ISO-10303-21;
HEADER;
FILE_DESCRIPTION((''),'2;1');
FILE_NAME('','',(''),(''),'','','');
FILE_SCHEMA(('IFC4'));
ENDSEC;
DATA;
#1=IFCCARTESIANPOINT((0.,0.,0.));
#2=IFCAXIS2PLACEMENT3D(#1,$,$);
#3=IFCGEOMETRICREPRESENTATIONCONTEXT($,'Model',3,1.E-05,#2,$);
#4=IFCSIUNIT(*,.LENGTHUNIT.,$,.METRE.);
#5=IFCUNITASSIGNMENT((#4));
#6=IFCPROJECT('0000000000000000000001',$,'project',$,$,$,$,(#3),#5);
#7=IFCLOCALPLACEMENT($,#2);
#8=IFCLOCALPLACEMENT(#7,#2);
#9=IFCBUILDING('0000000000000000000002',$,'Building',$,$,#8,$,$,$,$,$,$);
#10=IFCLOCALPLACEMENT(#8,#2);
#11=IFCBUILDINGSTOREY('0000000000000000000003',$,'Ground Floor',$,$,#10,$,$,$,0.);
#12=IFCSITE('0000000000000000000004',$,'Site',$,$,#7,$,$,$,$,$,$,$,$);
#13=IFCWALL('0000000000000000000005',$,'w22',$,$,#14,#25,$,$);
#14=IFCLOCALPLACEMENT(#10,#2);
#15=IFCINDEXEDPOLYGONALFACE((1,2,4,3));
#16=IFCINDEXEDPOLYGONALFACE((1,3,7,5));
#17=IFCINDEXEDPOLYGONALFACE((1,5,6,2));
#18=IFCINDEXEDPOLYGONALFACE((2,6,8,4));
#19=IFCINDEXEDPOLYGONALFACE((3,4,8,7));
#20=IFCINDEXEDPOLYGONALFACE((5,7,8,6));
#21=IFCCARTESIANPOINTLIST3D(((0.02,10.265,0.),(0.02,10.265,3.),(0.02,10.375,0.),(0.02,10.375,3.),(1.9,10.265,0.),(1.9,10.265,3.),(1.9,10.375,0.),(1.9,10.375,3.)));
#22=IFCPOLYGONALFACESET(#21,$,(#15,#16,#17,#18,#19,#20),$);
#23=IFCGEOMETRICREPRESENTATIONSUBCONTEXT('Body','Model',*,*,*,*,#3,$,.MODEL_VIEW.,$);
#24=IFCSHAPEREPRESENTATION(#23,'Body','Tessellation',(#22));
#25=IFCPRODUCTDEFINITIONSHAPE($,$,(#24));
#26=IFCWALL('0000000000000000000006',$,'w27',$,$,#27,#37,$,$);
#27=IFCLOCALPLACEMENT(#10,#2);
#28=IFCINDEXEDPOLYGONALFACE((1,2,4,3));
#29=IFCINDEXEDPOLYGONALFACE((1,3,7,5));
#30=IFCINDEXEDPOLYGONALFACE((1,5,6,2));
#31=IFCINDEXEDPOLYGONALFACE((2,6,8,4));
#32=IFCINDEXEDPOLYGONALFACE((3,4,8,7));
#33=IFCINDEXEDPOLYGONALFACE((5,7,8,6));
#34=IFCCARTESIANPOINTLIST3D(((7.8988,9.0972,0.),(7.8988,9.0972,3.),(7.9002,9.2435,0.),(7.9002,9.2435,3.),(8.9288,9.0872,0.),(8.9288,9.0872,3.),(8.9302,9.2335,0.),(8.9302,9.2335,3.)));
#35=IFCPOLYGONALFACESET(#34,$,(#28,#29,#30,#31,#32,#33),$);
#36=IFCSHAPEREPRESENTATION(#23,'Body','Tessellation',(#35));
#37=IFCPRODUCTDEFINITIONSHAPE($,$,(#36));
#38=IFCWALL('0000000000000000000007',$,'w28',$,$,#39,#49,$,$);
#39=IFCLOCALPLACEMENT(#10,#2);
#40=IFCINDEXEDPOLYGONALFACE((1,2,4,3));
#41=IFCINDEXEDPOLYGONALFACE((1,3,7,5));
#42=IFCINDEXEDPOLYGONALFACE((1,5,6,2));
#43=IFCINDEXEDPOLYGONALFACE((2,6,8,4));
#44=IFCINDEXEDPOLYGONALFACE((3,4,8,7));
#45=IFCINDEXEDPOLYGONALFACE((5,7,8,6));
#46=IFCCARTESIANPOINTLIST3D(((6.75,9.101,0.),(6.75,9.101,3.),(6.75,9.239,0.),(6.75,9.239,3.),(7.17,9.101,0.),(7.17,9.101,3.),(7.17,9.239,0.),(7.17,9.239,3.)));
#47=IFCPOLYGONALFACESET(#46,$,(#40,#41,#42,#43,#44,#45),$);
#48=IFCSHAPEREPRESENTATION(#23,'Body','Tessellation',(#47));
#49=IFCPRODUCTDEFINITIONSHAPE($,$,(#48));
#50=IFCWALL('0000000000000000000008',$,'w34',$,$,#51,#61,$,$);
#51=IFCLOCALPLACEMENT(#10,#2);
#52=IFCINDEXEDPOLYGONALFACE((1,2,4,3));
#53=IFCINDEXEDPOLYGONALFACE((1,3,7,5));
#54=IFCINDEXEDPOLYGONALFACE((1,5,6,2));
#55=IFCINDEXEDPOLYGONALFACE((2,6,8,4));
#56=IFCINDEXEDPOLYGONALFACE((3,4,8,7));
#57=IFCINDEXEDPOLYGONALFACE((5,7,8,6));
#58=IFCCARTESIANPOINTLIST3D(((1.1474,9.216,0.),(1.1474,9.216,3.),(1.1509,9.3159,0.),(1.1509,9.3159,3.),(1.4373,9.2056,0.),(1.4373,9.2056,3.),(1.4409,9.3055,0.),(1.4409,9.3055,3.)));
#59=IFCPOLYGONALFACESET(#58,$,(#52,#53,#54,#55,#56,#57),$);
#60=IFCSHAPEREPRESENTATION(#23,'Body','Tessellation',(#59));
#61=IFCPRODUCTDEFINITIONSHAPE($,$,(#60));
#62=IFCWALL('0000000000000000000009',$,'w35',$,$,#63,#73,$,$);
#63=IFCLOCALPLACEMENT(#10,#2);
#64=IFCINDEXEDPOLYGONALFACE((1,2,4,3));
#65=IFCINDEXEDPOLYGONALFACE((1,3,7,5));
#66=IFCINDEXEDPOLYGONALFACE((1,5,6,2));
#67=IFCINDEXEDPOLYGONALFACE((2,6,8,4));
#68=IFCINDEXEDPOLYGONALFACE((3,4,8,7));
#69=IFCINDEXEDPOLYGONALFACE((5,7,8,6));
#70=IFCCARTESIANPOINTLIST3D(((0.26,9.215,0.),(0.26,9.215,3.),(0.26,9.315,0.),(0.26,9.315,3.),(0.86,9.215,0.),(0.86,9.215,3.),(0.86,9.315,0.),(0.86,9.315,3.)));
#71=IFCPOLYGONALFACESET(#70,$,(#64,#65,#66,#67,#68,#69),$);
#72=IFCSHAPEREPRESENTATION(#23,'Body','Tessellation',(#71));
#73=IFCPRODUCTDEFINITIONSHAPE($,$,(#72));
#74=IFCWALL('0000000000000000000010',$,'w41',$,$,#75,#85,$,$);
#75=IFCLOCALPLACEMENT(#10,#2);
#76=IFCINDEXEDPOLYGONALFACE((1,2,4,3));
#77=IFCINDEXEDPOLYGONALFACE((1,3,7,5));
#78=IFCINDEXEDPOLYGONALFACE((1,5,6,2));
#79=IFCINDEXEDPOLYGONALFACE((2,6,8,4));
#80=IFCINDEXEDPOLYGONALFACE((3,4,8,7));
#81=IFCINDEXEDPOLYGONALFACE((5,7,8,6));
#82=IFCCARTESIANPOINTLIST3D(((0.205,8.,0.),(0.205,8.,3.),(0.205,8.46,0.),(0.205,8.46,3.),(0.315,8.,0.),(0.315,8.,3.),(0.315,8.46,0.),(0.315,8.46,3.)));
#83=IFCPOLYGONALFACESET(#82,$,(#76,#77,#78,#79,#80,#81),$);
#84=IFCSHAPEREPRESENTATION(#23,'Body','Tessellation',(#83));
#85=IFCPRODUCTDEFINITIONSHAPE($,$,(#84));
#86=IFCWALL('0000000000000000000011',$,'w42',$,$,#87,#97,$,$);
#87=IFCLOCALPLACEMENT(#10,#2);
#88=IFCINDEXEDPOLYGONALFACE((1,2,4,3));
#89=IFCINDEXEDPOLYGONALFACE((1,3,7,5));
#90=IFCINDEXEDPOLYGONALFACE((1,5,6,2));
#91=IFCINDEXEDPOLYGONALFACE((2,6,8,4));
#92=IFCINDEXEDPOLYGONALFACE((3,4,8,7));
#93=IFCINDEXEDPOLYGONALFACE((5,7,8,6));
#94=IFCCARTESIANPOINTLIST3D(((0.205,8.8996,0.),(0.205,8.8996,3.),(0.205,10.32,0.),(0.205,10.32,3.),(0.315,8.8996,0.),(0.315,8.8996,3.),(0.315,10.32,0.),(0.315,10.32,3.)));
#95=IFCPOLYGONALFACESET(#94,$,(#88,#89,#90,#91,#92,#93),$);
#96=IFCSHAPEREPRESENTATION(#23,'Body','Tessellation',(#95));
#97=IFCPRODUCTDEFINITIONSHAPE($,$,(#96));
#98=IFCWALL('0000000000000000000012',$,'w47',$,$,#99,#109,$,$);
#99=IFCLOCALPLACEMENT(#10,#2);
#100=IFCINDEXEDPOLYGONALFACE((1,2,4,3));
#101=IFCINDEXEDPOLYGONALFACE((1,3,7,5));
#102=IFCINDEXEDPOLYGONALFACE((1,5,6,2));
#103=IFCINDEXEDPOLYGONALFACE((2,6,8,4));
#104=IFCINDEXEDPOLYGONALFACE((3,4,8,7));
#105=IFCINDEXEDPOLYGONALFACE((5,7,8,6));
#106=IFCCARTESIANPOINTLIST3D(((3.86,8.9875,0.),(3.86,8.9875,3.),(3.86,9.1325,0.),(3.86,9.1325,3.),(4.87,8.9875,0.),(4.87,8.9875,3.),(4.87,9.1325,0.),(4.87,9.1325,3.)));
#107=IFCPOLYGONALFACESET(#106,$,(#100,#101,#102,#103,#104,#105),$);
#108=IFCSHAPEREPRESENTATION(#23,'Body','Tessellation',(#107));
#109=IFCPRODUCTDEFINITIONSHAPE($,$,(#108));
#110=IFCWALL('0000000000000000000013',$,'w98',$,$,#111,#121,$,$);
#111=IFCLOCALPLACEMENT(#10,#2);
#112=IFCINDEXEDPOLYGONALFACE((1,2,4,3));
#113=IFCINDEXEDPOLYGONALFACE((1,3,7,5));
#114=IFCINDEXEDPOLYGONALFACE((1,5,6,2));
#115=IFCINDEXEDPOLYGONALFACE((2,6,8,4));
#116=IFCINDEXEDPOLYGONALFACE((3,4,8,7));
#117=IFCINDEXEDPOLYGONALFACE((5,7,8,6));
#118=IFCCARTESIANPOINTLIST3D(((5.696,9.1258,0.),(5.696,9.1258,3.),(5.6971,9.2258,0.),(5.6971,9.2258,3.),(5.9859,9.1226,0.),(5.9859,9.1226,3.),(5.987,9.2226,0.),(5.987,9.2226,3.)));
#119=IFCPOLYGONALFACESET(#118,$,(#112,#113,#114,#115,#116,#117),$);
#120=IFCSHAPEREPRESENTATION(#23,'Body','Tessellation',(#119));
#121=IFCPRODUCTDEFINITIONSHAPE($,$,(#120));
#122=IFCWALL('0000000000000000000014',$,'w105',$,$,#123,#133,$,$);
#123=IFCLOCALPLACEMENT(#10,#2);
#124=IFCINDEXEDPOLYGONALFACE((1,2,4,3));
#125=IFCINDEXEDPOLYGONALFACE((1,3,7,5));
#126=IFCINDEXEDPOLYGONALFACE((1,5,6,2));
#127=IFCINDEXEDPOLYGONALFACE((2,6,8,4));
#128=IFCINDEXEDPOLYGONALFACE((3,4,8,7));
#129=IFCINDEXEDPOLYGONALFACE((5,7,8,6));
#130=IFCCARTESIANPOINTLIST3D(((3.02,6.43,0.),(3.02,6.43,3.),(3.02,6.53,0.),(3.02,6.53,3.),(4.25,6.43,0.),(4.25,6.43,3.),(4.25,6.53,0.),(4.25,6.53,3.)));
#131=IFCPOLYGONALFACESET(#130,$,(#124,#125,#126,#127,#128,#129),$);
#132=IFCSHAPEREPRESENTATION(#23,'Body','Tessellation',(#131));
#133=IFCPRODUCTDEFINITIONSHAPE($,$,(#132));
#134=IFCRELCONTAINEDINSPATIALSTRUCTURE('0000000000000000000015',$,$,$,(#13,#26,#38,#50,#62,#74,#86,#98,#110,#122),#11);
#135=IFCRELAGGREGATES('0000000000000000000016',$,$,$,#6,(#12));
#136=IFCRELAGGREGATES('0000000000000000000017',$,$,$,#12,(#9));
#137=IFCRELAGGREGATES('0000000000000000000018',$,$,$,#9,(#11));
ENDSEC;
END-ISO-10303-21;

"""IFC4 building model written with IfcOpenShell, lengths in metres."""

from ifc_helpers import new_model, si_unit, frame, origin, place, context, subcontext, project, spatial, polyline, outline, extrude, element, save


model = new_model("IFC4")

# Units and contexts
model_context = context("Model", 3, precision=1e-05, world=origin())
body_context = subcontext(model_context, "Body", "Model", "MODEL_VIEW")
ifc_project = project(units=[si_unit("LENGTHUNIT", "METRE")], contexts=[model_context])

# Site, building, storey
site_placement = place(None, origin())
site = spatial("IfcSite", under=ifc_project, at=site_placement, Name="Site")
building_placement = place(site_placement, origin())
building = spatial("IfcBuilding", under=site, at=building_placement, Name="Building")
storey_placement = place(building_placement, origin())
storey = spatial("IfcBuildingStorey", under=building, at=storey_placement, Name="Ground Floor", Elevation=0.0)

# Walls
wall_1_placement = place(storey_placement, frame((0.02, 10.32, 0.0), x_axis=(1.0, 0.0, 0.0)))
element("IfcWall", 1, at=wall_1_placement, inside=storey, Name="w22", context=body_context, shape_type="SweptSolid", body=[
    extrude(outline(polyline([(0.0, -0.055), (1.88, -0.055), (1.88, 0.055), (0.0, 0.055), (0.0, -0.055)])), origin(), (0.0, 0.0, 1.0), 3.0),
])
wall_2_placement = place(storey_placement, frame((7.8995, 9.1703, 0.0), x_axis=(0.999953, -0.009709, 0.0)))
element("IfcWall", 2, at=wall_2_placement, inside=storey, Name="w27", context=body_context, shape_type="SweptSolid", body=[
    extrude(outline(polyline([(0.0, -0.0731), (1.0301, -0.0731), (1.0301, 0.0731), (0.0, 0.0731), (0.0, -0.0731)])), origin(), (0.0, 0.0, 1.0), 3.0),
])
wall_3_placement = place(storey_placement, frame((6.75, 9.17, 0.0), x_axis=(1.0, 0.0, 0.0)))
element("IfcWall", 3, at=wall_3_placement, inside=storey, Name="w28", context=body_context, shape_type="SweptSolid", body=[
    extrude(outline(polyline([(0.0, -0.069), (0.42, -0.069), (0.42, 0.069), (0.0, 0.069), (0.0, -0.069)])), origin(), (0.0, 0.0, 1.0), 3.0),
])
wall_4_placement = place(storey_placement, frame((1.1491, 9.2659, 0.0), x_axis=(0.999363, -0.035694, 0.0)))
element("IfcWall", 4, at=wall_4_placement, inside=storey, Name="w34", context=body_context, shape_type="SweptSolid", body=[
    extrude(outline(polyline([(0.0, -0.05), (0.2902, -0.05), (0.2902, 0.05), (0.0, 0.05), (0.0, -0.05)])), origin(), (0.0, 0.0, 1.0), 3.0),
])
wall_5_placement = place(storey_placement, frame((0.26, 9.265, 0.0), x_axis=(1.0, 0.0, 0.0)))
element("IfcWall", 5, at=wall_5_placement, inside=storey, Name="w35", context=body_context, shape_type="SweptSolid", body=[
    extrude(outline(polyline([(0.0, -0.05), (0.6, -0.05), (0.6, 0.05), (0.0, 0.05), (0.0, -0.05)])), origin(), (0.0, 0.0, 1.0), 3.0),
])
wall_6_placement = place(storey_placement, frame((0.26, 8.0, 0.0), x_axis=(0.0, 1.0, 0.0)))
element("IfcWall", 6, at=wall_6_placement, inside=storey, Name="w41", context=body_context, shape_type="SweptSolid", body=[
    extrude(outline(polyline([(0.0, -0.055), (0.46, -0.055), (0.46, 0.055), (0.0, 0.055), (0.0, -0.055)])), origin(), (0.0, 0.0, 1.0), 3.0),
])
wall_7_placement = place(storey_placement, frame((0.26, 8.8996, 0.0), x_axis=(0.0, 1.0, 0.0)))
element("IfcWall", 7, at=wall_7_placement, inside=storey, Name="w42", context=body_context, shape_type="SweptSolid", body=[
    extrude(outline(polyline([(0.0, -0.055), (1.4204, -0.055), (1.4204, 0.055), (0.0, 0.055), (0.0, -0.055)])), origin(), (0.0, 0.0, 1.0), 3.0),
])
wall_8_placement = place(storey_placement, frame((3.86, 9.06, 0.0), x_axis=(1.0, 0.0, 0.0)))
element("IfcWall", 8, at=wall_8_placement, inside=storey, Name="w47", context=body_context, shape_type="SweptSolid", body=[
    extrude(outline(polyline([(0.0, -0.0725), (1.01, -0.0725), (1.01, 0.0725), (0.0, 0.0725), (0.0, -0.0725)])), origin(), (0.0, 0.0, 1.0), 3.0),
])
wall_9_placement = place(storey_placement, frame((5.6965, 9.1758, 0.0), x_axis=(0.999939, -0.011026, 0.0)))
element("IfcWall", 9, at=wall_9_placement, inside=storey, Name="w98", context=body_context, shape_type="SweptSolid", body=[
    extrude(outline(polyline([(0.0, -0.05), (0.2899, -0.05), (0.2899, 0.05), (0.0, 0.05), (0.0, -0.05)])), origin(), (0.0, 0.0, 1.0), 3.0),
])
wall_10_placement = place(storey_placement, frame((3.02, 6.48, 0.0), x_axis=(1.0, 0.0, 0.0)))
element("IfcWall", 10, at=wall_10_placement, inside=storey, Name="w105", context=body_context, shape_type="SweptSolid", body=[
    extrude(outline(polyline([(0.0, -0.05), (1.23, -0.05), (1.23, 0.05), (0.0, 0.05), (0.0, -0.05)])), origin(), (0.0, 0.0, 1.0), 3.0),
])

save(model, "model.ifc")
